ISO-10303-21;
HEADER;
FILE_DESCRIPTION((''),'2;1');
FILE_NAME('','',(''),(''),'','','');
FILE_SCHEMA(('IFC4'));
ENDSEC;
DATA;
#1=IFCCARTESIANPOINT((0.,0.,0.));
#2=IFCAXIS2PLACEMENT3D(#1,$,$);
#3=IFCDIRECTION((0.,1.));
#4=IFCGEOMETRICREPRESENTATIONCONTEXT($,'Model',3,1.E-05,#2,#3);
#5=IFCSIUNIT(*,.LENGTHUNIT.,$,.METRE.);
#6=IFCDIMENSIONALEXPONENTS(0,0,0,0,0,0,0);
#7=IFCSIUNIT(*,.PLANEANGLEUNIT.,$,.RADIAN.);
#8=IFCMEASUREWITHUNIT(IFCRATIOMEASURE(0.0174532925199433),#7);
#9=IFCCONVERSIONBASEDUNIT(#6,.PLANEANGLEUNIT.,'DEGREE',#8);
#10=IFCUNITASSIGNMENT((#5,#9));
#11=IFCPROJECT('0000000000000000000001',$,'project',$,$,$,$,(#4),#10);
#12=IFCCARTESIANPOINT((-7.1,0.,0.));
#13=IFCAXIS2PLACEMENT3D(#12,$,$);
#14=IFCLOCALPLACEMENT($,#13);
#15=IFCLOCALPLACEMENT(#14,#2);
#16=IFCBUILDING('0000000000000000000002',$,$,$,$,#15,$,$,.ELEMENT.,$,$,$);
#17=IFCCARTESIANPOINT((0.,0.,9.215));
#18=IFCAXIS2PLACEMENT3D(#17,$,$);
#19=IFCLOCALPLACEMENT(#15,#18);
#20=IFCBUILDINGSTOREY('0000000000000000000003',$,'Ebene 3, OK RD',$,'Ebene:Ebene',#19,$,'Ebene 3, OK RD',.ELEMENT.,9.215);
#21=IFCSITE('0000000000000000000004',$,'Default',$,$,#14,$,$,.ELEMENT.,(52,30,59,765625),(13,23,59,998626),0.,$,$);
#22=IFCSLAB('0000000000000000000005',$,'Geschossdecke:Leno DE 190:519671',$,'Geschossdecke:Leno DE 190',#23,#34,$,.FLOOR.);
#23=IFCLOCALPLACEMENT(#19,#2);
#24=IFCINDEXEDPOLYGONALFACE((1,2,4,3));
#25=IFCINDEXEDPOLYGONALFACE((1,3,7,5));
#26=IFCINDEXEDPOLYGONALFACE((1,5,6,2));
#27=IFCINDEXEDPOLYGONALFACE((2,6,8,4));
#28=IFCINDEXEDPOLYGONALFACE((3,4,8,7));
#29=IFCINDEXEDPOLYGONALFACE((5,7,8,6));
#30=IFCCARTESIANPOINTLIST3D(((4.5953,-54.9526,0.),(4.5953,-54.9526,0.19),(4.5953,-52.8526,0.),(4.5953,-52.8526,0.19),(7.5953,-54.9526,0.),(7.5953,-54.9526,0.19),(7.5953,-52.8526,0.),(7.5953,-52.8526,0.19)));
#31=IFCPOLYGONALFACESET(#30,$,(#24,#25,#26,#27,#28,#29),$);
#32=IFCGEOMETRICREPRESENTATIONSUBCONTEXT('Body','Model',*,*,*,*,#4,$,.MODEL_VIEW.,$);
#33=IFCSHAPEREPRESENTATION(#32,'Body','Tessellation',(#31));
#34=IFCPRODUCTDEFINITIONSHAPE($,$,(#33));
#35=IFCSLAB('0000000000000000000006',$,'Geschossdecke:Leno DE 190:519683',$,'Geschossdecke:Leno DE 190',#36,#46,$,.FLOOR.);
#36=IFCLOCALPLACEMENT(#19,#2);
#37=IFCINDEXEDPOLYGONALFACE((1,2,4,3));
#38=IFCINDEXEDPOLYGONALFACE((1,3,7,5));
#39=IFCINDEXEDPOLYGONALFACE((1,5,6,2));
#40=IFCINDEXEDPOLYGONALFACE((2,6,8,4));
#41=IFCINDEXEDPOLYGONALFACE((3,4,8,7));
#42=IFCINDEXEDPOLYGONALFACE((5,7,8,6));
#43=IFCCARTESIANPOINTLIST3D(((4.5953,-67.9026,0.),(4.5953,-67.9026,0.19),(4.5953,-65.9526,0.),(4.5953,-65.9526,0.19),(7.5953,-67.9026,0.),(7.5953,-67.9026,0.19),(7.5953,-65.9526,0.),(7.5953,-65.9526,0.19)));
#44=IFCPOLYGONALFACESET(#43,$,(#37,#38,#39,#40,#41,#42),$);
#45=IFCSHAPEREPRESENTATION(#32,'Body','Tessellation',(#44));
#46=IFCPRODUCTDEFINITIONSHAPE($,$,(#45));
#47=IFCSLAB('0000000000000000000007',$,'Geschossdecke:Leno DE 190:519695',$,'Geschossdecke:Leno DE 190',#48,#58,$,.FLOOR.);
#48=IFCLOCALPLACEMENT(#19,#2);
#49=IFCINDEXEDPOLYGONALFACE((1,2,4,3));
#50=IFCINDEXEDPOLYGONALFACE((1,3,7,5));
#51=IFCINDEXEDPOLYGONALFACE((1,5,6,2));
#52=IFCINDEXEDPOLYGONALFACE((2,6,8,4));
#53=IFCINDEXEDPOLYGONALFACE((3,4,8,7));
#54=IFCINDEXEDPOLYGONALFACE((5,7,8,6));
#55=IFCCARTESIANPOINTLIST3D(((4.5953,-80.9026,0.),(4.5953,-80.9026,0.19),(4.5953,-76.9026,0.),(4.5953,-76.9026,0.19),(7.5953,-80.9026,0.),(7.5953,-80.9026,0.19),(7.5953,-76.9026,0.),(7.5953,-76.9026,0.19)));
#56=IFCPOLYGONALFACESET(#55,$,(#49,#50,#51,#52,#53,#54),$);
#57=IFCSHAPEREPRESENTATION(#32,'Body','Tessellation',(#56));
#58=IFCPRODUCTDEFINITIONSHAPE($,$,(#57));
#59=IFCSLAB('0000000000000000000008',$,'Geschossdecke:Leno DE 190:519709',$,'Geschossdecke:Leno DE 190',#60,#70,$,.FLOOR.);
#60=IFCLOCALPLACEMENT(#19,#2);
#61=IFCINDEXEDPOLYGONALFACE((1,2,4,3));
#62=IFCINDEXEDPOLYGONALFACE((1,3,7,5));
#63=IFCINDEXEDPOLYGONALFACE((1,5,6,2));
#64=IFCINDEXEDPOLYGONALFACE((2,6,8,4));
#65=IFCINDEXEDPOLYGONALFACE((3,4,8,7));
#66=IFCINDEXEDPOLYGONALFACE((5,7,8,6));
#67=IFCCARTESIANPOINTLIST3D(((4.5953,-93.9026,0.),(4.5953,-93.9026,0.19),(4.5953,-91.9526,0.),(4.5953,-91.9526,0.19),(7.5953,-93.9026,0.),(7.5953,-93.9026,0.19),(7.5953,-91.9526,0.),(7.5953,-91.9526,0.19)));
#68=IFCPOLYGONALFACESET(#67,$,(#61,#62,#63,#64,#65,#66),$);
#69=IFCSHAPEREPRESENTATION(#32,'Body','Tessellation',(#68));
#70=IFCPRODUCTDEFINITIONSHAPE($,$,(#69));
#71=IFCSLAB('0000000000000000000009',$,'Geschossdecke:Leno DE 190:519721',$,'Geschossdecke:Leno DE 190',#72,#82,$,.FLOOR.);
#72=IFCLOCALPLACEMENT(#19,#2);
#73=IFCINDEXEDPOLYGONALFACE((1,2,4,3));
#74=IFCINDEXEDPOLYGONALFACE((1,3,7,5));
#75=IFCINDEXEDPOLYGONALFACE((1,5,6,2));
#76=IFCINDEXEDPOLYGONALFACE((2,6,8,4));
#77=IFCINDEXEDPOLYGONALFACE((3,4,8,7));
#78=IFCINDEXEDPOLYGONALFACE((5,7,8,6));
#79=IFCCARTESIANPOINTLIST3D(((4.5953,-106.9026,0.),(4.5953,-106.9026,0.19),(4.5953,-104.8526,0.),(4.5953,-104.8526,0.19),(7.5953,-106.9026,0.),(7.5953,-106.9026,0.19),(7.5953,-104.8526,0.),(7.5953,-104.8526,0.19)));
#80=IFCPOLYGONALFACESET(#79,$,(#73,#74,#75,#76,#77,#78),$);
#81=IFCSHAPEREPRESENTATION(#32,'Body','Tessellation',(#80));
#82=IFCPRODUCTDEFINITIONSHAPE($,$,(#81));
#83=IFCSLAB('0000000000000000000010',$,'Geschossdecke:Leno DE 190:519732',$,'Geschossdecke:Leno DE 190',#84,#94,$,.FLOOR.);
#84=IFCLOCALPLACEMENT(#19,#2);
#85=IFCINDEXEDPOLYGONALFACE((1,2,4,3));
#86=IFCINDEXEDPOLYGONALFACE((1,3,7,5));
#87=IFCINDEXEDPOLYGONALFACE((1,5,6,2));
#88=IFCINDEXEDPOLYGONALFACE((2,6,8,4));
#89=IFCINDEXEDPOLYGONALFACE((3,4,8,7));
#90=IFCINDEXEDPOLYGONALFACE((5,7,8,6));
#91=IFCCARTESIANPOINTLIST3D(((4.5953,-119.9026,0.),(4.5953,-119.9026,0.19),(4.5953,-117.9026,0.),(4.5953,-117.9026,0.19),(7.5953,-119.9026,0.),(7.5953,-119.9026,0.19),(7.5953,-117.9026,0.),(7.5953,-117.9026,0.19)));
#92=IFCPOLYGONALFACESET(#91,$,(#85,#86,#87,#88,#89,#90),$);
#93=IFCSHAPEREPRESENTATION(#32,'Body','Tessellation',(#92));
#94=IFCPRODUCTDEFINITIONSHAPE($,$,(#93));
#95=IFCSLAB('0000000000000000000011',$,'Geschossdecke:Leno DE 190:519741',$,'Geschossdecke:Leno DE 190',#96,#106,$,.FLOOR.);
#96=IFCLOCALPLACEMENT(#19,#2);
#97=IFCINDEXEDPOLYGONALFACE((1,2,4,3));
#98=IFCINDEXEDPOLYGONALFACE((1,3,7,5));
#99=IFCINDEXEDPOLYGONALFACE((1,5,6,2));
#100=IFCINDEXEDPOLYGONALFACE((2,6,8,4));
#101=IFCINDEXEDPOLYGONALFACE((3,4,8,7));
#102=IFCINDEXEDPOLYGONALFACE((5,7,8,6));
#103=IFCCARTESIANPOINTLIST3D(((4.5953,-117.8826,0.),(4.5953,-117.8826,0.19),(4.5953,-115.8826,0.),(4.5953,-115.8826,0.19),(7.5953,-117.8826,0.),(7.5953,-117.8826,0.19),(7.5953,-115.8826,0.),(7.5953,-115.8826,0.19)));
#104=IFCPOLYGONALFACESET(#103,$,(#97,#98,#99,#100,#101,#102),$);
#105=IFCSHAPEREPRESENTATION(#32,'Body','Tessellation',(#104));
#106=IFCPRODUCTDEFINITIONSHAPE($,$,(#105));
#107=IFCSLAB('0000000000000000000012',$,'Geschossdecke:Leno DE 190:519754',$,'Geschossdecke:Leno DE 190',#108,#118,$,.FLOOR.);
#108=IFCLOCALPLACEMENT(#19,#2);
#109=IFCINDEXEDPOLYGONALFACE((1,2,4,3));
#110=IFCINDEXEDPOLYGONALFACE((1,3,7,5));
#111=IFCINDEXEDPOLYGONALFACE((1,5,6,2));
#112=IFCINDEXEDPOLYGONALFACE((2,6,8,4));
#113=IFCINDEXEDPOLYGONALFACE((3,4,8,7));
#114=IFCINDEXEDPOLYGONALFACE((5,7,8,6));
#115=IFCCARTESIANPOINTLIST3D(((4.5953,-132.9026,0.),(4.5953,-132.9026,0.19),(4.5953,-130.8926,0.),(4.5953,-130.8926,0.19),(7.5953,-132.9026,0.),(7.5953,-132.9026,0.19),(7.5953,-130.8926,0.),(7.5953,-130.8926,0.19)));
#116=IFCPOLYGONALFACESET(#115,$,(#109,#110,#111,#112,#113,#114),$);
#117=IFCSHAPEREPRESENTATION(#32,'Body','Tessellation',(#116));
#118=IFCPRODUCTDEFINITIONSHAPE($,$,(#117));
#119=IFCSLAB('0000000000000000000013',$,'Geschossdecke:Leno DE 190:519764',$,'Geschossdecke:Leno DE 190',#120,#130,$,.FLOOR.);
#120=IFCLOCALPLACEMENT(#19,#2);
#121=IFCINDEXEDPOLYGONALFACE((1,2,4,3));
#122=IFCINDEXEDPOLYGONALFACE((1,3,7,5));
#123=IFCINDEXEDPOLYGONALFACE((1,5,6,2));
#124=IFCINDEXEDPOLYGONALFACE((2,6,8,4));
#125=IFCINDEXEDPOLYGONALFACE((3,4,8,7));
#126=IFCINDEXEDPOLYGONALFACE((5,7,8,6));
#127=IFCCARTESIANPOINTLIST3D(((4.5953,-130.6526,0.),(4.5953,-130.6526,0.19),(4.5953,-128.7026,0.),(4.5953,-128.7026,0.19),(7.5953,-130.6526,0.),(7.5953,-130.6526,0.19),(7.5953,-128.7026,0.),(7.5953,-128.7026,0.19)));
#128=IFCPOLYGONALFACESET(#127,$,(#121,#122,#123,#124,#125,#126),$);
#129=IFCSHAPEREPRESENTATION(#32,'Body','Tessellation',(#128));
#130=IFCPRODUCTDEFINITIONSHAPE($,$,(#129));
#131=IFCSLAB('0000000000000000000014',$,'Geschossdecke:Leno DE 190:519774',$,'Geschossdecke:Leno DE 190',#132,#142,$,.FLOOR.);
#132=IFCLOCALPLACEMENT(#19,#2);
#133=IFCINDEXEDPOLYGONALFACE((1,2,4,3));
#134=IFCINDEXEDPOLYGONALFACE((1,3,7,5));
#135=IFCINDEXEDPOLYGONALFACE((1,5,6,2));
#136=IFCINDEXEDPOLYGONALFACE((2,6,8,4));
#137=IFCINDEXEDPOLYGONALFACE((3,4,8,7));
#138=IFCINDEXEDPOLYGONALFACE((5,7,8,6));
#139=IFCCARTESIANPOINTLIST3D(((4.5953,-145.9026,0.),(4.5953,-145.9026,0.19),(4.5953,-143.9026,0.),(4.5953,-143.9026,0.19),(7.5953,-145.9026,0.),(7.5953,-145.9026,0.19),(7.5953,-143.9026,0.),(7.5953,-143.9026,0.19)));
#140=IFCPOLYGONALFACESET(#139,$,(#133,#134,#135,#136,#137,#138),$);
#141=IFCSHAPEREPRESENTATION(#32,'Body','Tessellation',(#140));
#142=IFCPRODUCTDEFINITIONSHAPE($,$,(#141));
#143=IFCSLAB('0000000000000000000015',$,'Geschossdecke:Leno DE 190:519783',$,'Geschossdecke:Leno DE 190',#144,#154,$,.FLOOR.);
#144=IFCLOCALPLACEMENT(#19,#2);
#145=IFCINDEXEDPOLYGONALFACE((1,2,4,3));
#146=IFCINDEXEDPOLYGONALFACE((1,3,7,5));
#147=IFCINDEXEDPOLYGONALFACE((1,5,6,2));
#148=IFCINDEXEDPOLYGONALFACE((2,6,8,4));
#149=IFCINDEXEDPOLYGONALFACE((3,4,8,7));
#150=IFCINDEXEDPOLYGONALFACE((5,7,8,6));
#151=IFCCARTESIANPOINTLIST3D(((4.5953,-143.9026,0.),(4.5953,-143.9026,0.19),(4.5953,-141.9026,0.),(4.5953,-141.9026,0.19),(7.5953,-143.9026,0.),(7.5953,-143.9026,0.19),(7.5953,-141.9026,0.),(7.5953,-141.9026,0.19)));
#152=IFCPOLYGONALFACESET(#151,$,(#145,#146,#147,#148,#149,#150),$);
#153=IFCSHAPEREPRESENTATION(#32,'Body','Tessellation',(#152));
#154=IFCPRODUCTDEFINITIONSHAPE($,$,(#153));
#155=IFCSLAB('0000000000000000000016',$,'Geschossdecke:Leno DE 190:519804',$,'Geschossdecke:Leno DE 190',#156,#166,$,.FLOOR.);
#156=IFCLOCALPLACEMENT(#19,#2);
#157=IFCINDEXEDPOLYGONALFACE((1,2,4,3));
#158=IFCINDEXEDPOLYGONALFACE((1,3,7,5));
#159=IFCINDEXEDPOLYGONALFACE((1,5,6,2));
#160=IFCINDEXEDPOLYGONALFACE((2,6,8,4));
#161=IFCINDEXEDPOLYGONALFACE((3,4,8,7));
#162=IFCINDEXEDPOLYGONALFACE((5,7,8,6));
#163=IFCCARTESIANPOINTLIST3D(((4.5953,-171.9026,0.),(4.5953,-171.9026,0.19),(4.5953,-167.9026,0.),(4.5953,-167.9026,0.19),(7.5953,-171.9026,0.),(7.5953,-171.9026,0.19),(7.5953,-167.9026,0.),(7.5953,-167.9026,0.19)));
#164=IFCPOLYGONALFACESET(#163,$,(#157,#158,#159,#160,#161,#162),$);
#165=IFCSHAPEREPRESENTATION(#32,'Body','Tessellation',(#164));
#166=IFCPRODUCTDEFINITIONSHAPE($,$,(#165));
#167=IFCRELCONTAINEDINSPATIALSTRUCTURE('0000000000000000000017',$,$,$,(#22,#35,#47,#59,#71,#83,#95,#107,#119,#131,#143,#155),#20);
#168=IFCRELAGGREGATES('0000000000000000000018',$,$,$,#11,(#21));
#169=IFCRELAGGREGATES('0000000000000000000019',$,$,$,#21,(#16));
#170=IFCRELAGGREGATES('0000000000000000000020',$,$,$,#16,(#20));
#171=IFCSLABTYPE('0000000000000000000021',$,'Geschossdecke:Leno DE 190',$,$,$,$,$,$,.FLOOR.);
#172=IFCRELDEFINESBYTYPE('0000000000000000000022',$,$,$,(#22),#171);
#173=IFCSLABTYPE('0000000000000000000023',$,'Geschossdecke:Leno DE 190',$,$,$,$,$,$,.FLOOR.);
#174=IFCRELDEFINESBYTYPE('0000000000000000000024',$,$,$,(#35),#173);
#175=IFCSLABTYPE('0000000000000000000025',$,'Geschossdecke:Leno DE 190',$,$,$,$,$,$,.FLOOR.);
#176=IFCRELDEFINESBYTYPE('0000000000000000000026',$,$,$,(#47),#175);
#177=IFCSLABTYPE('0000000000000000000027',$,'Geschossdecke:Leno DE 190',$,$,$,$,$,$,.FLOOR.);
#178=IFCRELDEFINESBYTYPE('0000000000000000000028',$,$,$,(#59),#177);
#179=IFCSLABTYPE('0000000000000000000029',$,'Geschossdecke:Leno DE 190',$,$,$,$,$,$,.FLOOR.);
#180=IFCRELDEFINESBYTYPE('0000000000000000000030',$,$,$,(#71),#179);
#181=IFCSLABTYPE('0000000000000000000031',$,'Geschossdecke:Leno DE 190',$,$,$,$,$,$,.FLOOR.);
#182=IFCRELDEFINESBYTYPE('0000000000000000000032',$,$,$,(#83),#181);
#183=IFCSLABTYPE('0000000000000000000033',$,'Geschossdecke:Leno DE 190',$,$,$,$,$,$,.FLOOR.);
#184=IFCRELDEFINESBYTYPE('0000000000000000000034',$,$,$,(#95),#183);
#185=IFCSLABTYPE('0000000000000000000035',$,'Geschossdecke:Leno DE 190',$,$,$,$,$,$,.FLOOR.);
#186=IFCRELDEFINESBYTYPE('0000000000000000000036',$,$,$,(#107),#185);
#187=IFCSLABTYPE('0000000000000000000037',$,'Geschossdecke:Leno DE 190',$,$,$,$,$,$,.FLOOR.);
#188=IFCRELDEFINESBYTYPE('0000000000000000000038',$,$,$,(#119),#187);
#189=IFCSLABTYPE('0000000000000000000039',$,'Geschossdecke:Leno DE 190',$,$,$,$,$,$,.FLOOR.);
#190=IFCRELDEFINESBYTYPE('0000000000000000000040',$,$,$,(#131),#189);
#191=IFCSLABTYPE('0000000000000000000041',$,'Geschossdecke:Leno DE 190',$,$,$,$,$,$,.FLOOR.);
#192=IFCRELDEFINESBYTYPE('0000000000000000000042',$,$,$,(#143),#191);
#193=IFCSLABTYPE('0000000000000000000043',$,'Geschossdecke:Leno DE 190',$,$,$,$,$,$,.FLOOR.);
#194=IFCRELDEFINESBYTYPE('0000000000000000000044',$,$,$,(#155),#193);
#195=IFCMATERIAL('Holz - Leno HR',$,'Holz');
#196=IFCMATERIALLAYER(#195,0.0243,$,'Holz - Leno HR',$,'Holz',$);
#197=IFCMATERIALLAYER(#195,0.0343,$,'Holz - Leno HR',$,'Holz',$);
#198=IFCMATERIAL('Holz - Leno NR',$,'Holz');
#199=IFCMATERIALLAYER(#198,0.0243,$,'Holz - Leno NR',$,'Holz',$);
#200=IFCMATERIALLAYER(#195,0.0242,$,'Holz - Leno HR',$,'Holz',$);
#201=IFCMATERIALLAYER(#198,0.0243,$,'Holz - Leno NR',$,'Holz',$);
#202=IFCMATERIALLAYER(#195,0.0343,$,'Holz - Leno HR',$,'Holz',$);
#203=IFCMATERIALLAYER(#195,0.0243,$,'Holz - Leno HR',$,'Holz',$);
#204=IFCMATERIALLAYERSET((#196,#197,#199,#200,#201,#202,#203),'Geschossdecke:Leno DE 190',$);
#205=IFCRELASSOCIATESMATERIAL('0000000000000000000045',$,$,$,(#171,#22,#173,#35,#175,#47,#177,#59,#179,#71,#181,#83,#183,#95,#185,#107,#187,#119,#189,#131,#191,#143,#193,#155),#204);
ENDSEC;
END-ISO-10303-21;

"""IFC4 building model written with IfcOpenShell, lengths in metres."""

from ifc_helpers import new_model, entity, si_unit, converted_unit, direction, frame, origin, place, context, subcontext, project, spatial, indexed_curve, outline, extrude, material, layer, layer_set, type_object, element, save


model = new_model("IFC4")

# Units and contexts
model_context = context("Model", 3, precision=1e-05, world=origin(), true_north=direction((0.0, 1.0)))
body_context = subcontext(model_context, "Body", "Model", "MODEL_VIEW")
ifc_project = project(units=[si_unit("LENGTHUNIT", "METRE"), converted_unit("PLANEANGLEUNIT", "DEGREE", entity("IfcRatioMeasure", 0.0174532925199433), si_unit("PLANEANGLEUNIT", "RADIAN"), dimensions=[0, 0, 0, 0, 0, 0, 0])], contexts=[model_context])

# Site, building, storey
site_placement = place(None, frame((-7.1, 0.0, 0.0)))
site = spatial("IfcSite", under=ifc_project, at=site_placement, Name="Default", CompositionType="ELEMENT", RefLatitude=(52, 30, 59, 765625), RefLongitude=(13, 23, 59, 998626), RefElevation=0.0)
building_placement = place(site_placement, origin())
building = spatial("IfcBuilding", under=site, at=building_placement, CompositionType="ELEMENT")
storey_placement = place(building_placement, frame((0.0, 0.0, 9.215)))
storey = spatial("IfcBuildingStorey", under=building, at=storey_placement, Name="Ebene 3, OK RD", ObjectType="Ebene:Ebene", LongName="Ebene 3, OK RD", CompositionType="ELEMENT", Elevation=9.215)

# Slabs
ifc_material_1 = material(Name="Holz - Leno HR", Category="Holz")
ifc_layer_1 = layer(ifc_material_1, 0.0243, Name="Holz - Leno HR", Category="Holz")
ifc_layer_2 = layer(ifc_material_1, 0.0343, Name="Holz - Leno HR", Category="Holz")
ifc_material_2 = material(Name="Holz - Leno NR", Category="Holz")
ifc_layer_3 = layer(ifc_material_2, 0.0243, Name="Holz - Leno NR", Category="Holz")
ifc_layer_4 = layer(ifc_material_1, 0.0242, Name="Holz - Leno HR", Category="Holz")
ifc_layer_5 = layer(ifc_material_2, 0.0243, Name="Holz - Leno NR", Category="Holz")
ifc_layer_6 = layer(ifc_material_1, 0.0343, Name="Holz - Leno HR", Category="Holz")
ifc_layer_7 = layer(ifc_material_1, 0.0243, Name="Holz - Leno HR", Category="Holz")
ifc_layer_set_1 = layer_set([ifc_layer_1, ifc_layer_2, ifc_layer_3, ifc_layer_4, ifc_layer_5, ifc_layer_6, ifc_layer_7], Name="Geschossdecke:Leno DE 190")
slab_type_1 = type_object("IfcSlabType", Name="Geschossdecke:Leno DE 190", PredefinedType="FLOOR", material=ifc_layer_set_1)
slab_1_placement = place(storey_placement, origin())
element("IfcSlab", 1, at=slab_1_placement, inside=storey, type_object=slab_type_1, material=ifc_layer_set_1, Name="Geschossdecke:Leno DE 190:519671", ObjectType="Geschossdecke:Leno DE 190", PredefinedType="FLOOR", context=body_context, shape_type="SweptSolid", body=[
    extrude(outline(indexed_curve([(-1.05, -1.5), (1.05, -1.5), (1.05, 1.5), (-1.05, 1.5), (-1.05, -1.5)], self_intersect=False)), frame((6.0953, -53.9026, 0.19), z_axis=(0.0, 0.0, -1.0), x_axis=(0.0, 1.0, 0.0)), (0.0, 0.0, 1.0), 0.19),
])
slab_type_2 = type_object("IfcSlabType", Name="Geschossdecke:Leno DE 190", PredefinedType="FLOOR", material=ifc_layer_set_1)
slab_2_placement = place(storey_placement, origin())
element("IfcSlab", 2, at=slab_2_placement, inside=storey, type_object=slab_type_2, material=ifc_layer_set_1, Name="Geschossdecke:Leno DE 190:519683", ObjectType="Geschossdecke:Leno DE 190", PredefinedType="FLOOR", context=body_context, shape_type="SweptSolid", body=[
    extrude(outline(indexed_curve([(-0.975, -1.5), (0.975, -1.5), (0.975, 1.5), (-0.975, 1.5), (-0.975, -1.5)], self_intersect=False)), frame((6.0953, -66.9276, 0.19), z_axis=(0.0, 0.0, -1.0), x_axis=(0.0, 1.0, 0.0)), (0.0, 0.0, 1.0), 0.19),
])
slab_type_3 = type_object("IfcSlabType", Name="Geschossdecke:Leno DE 190", PredefinedType="FLOOR", material=ifc_layer_set_1)
slab_3_placement = place(storey_placement, origin())
element("IfcSlab", 3, at=slab_3_placement, inside=storey, type_object=slab_type_3, material=ifc_layer_set_1, Name="Geschossdecke:Leno DE 190:519695", ObjectType="Geschossdecke:Leno DE 190", PredefinedType="FLOOR", context=body_context, shape_type="SweptSolid", body=[
    extrude(outline(indexed_curve([(-2.0, -1.5), (2.0, -1.5), (2.0, 1.5), (-2.0, 1.5), (-2.0, -1.5)], self_intersect=False)), frame((6.0953, -78.9026, 0.19), z_axis=(0.0, 0.0, -1.0), x_axis=(0.0, 1.0, 0.0)), (0.0, 0.0, 1.0), 0.19),
])
slab_type_4 = type_object("IfcSlabType", Name="Geschossdecke:Leno DE 190", PredefinedType="FLOOR", material=ifc_layer_set_1)
slab_4_placement = place(storey_placement, origin())
element("IfcSlab", 4, at=slab_4_placement, inside=storey, type_object=slab_type_4, material=ifc_layer_set_1, Name="Geschossdecke:Leno DE 190:519709", ObjectType="Geschossdecke:Leno DE 190", PredefinedType="FLOOR", context=body_context, shape_type="SweptSolid", body=[
    extrude(outline(indexed_curve([(-0.975, -1.5), (0.975, -1.5), (0.975, 1.5), (-0.975, 1.5), (-0.975, -1.5)], self_intersect=False)), frame((6.0953, -92.9276, 0.19), z_axis=(0.0, 0.0, -1.0), x_axis=(0.0, 1.0, 0.0)), (0.0, 0.0, 1.0), 0.19),
])
slab_type_5 = type_object("IfcSlabType", Name="Geschossdecke:Leno DE 190", PredefinedType="FLOOR", material=ifc_layer_set_1)
slab_5_placement = place(storey_placement, origin())
element("IfcSlab", 5, at=slab_5_placement, inside=storey, type_object=slab_type_5, material=ifc_layer_set_1, Name="Geschossdecke:Leno DE 190:519721", ObjectType="Geschossdecke:Leno DE 190", PredefinedType="FLOOR", context=body_context, shape_type="SweptSolid", body=[
    extrude(outline(indexed_curve([(-1.025, -1.5), (1.025, -1.5), (1.025, 1.5), (-1.025, 1.5), (-1.025, -1.5)], self_intersect=False)), frame((6.0953, -105.8776, 0.19), z_axis=(0.0, 0.0, -1.0), x_axis=(0.0, 1.0, 0.0)), (0.0, 0.0, 1.0), 0.19),
])
slab_type_6 = type_object("IfcSlabType", Name="Geschossdecke:Leno DE 190", PredefinedType="FLOOR", material=ifc_layer_set_1)
slab_6_placement = place(storey_placement, origin())
element("IfcSlab", 6, at=slab_6_placement, inside=storey, type_object=slab_type_6, material=ifc_layer_set_1, Name="Geschossdecke:Leno DE 190:519732", ObjectType="Geschossdecke:Leno DE 190", PredefinedType="FLOOR", context=body_context, shape_type="SweptSolid", body=[
    extrude(outline(indexed_curve([(-1.0, -1.5), (1.0, -1.5), (1.0, 1.5), (-1.0, 1.5), (-1.0, -1.5)], self_intersect=False)), frame((6.0953, -118.9026, 0.19), z_axis=(0.0, 0.0, -1.0), x_axis=(0.0, 1.0, 0.0)), (0.0, 0.0, 1.0), 0.19),
])
slab_type_7 = type_object("IfcSlabType", Name="Geschossdecke:Leno DE 190", PredefinedType="FLOOR", material=ifc_layer_set_1)
slab_7_placement = place(storey_placement, origin())
element("IfcSlab", 7, at=slab_7_placement, inside=storey, type_object=slab_type_7, material=ifc_layer_set_1, Name="Geschossdecke:Leno DE 190:519741", ObjectType="Geschossdecke:Leno DE 190", PredefinedType="FLOOR", context=body_context, shape_type="SweptSolid", body=[
    extrude(outline(indexed_curve([(-1.0, -1.5), (1.0, -1.5), (1.0, 1.5), (-1.0, 1.5), (-1.0, -1.5)], self_intersect=False)), frame((6.0953, -116.8826, 0.19), z_axis=(0.0, 0.0, -1.0), x_axis=(0.0, 1.0, 0.0)), (0.0, 0.0, 1.0), 0.19),
])
slab_type_8 = type_object("IfcSlabType", Name="Geschossdecke:Leno DE 190", PredefinedType="FLOOR", material=ifc_layer_set_1)
slab_8_placement = place(storey_placement, origin())
element("IfcSlab", 8, at=slab_8_placement, inside=storey, type_object=slab_type_8, material=ifc_layer_set_1, Name="Geschossdecke:Leno DE 190:519754", ObjectType="Geschossdecke:Leno DE 190", PredefinedType="FLOOR", context=body_context, shape_type="SweptSolid", body=[
    extrude(outline(indexed_curve([(-1.005, -1.5), (1.005, -1.5), (1.005, 1.5), (-1.005, 1.5), (-1.005, -1.5)], self_intersect=False)), frame((6.0953, -131.8976, 0.19), z_axis=(0.0, 0.0, -1.0), x_axis=(0.0, 1.0, 0.0)), (0.0, 0.0, 1.0), 0.19),
])
slab_type_9 = type_object("IfcSlabType", Name="Geschossdecke:Leno DE 190", PredefinedType="FLOOR", material=ifc_layer_set_1)
slab_9_placement = place(storey_placement, origin())
element("IfcSlab", 9, at=slab_9_placement, inside=storey, type_object=slab_type_9, material=ifc_layer_set_1, Name="Geschossdecke:Leno DE 190:519764", ObjectType="Geschossdecke:Leno DE 190", PredefinedType="FLOOR", context=body_context, shape_type="SweptSolid", body=[
    extrude(outline(indexed_curve([(-0.975, -1.5), (0.975, -1.5), (0.975, 1.5), (-0.975, 1.5), (-0.975, -1.5)], self_intersect=False)), frame((6.0953, -129.6776, 0.19), z_axis=(0.0, 0.0, -1.0), x_axis=(0.0, 1.0, 0.0)), (0.0, 0.0, 1.0), 0.19),
])
slab_type_10 = type_object("IfcSlabType", Name="Geschossdecke:Leno DE 190", PredefinedType="FLOOR", material=ifc_layer_set_1)
slab_10_placement = place(storey_placement, origin())
element("IfcSlab", 10, at=slab_10_placement, inside=storey, type_object=slab_type_10, material=ifc_layer_set_1, Name="Geschossdecke:Leno DE 190:519774", ObjectType="Geschossdecke:Leno DE 190", PredefinedType="FLOOR", context=body_context, shape_type="SweptSolid", body=[
    extrude(outline(indexed_curve([(-1.0, -1.5), (1.0, -1.5), (1.0, 1.5), (-1.0, 1.5), (-1.0, -1.5)], self_intersect=False)), frame((6.0953, -144.9026, 0.19), z_axis=(0.0, 0.0, -1.0), x_axis=(0.0, 1.0, 0.0)), (0.0, 0.0, 1.0), 0.19),
])
slab_type_11 = type_object("IfcSlabType", Name="Geschossdecke:Leno DE 190", PredefinedType="FLOOR", material=ifc_layer_set_1)
slab_11_placement = place(storey_placement, origin())
element("IfcSlab", 11, at=slab_11_placement, inside=storey, type_object=slab_type_11, material=ifc_layer_set_1, Name="Geschossdecke:Leno DE 190:519783", ObjectType="Geschossdecke:Leno DE 190", PredefinedType="FLOOR", context=body_context, shape_type="SweptSolid", body=[
    extrude(outline(indexed_curve([(-1.0, -1.5), (1.0, -1.5), (1.0, 1.5), (-1.0, 1.5), (-1.0, -1.5)], self_intersect=False)), frame((6.0953, -142.9026, 0.19), z_axis=(0.0, 0.0, -1.0), x_axis=(0.0, 1.0, 0.0)), (0.0, 0.0, 1.0), 0.19),
])
slab_type_12 = type_object("IfcSlabType", Name="Geschossdecke:Leno DE 190", PredefinedType="FLOOR", material=ifc_layer_set_1)
slab_12_placement = place(storey_placement, origin())
element("IfcSlab", 12, at=slab_12_placement, inside=storey, type_object=slab_type_12, material=ifc_layer_set_1, Name="Geschossdecke:Leno DE 190:519804", ObjectType="Geschossdecke:Leno DE 190", PredefinedType="FLOOR", context=body_context, shape_type="SweptSolid", body=[
    extrude(outline(indexed_curve([(-2.0, -1.5), (2.0, -1.5), (2.0, 1.5), (-2.0, 1.5), (-2.0, -1.5)], self_intersect=False)), frame((6.0953, -169.9026, 0.19), z_axis=(0.0, 0.0, -1.0), x_axis=(0.0, 1.0, 0.0)), (0.0, 0.0, 1.0), 0.19),
])

save(model, "model.ifc")
